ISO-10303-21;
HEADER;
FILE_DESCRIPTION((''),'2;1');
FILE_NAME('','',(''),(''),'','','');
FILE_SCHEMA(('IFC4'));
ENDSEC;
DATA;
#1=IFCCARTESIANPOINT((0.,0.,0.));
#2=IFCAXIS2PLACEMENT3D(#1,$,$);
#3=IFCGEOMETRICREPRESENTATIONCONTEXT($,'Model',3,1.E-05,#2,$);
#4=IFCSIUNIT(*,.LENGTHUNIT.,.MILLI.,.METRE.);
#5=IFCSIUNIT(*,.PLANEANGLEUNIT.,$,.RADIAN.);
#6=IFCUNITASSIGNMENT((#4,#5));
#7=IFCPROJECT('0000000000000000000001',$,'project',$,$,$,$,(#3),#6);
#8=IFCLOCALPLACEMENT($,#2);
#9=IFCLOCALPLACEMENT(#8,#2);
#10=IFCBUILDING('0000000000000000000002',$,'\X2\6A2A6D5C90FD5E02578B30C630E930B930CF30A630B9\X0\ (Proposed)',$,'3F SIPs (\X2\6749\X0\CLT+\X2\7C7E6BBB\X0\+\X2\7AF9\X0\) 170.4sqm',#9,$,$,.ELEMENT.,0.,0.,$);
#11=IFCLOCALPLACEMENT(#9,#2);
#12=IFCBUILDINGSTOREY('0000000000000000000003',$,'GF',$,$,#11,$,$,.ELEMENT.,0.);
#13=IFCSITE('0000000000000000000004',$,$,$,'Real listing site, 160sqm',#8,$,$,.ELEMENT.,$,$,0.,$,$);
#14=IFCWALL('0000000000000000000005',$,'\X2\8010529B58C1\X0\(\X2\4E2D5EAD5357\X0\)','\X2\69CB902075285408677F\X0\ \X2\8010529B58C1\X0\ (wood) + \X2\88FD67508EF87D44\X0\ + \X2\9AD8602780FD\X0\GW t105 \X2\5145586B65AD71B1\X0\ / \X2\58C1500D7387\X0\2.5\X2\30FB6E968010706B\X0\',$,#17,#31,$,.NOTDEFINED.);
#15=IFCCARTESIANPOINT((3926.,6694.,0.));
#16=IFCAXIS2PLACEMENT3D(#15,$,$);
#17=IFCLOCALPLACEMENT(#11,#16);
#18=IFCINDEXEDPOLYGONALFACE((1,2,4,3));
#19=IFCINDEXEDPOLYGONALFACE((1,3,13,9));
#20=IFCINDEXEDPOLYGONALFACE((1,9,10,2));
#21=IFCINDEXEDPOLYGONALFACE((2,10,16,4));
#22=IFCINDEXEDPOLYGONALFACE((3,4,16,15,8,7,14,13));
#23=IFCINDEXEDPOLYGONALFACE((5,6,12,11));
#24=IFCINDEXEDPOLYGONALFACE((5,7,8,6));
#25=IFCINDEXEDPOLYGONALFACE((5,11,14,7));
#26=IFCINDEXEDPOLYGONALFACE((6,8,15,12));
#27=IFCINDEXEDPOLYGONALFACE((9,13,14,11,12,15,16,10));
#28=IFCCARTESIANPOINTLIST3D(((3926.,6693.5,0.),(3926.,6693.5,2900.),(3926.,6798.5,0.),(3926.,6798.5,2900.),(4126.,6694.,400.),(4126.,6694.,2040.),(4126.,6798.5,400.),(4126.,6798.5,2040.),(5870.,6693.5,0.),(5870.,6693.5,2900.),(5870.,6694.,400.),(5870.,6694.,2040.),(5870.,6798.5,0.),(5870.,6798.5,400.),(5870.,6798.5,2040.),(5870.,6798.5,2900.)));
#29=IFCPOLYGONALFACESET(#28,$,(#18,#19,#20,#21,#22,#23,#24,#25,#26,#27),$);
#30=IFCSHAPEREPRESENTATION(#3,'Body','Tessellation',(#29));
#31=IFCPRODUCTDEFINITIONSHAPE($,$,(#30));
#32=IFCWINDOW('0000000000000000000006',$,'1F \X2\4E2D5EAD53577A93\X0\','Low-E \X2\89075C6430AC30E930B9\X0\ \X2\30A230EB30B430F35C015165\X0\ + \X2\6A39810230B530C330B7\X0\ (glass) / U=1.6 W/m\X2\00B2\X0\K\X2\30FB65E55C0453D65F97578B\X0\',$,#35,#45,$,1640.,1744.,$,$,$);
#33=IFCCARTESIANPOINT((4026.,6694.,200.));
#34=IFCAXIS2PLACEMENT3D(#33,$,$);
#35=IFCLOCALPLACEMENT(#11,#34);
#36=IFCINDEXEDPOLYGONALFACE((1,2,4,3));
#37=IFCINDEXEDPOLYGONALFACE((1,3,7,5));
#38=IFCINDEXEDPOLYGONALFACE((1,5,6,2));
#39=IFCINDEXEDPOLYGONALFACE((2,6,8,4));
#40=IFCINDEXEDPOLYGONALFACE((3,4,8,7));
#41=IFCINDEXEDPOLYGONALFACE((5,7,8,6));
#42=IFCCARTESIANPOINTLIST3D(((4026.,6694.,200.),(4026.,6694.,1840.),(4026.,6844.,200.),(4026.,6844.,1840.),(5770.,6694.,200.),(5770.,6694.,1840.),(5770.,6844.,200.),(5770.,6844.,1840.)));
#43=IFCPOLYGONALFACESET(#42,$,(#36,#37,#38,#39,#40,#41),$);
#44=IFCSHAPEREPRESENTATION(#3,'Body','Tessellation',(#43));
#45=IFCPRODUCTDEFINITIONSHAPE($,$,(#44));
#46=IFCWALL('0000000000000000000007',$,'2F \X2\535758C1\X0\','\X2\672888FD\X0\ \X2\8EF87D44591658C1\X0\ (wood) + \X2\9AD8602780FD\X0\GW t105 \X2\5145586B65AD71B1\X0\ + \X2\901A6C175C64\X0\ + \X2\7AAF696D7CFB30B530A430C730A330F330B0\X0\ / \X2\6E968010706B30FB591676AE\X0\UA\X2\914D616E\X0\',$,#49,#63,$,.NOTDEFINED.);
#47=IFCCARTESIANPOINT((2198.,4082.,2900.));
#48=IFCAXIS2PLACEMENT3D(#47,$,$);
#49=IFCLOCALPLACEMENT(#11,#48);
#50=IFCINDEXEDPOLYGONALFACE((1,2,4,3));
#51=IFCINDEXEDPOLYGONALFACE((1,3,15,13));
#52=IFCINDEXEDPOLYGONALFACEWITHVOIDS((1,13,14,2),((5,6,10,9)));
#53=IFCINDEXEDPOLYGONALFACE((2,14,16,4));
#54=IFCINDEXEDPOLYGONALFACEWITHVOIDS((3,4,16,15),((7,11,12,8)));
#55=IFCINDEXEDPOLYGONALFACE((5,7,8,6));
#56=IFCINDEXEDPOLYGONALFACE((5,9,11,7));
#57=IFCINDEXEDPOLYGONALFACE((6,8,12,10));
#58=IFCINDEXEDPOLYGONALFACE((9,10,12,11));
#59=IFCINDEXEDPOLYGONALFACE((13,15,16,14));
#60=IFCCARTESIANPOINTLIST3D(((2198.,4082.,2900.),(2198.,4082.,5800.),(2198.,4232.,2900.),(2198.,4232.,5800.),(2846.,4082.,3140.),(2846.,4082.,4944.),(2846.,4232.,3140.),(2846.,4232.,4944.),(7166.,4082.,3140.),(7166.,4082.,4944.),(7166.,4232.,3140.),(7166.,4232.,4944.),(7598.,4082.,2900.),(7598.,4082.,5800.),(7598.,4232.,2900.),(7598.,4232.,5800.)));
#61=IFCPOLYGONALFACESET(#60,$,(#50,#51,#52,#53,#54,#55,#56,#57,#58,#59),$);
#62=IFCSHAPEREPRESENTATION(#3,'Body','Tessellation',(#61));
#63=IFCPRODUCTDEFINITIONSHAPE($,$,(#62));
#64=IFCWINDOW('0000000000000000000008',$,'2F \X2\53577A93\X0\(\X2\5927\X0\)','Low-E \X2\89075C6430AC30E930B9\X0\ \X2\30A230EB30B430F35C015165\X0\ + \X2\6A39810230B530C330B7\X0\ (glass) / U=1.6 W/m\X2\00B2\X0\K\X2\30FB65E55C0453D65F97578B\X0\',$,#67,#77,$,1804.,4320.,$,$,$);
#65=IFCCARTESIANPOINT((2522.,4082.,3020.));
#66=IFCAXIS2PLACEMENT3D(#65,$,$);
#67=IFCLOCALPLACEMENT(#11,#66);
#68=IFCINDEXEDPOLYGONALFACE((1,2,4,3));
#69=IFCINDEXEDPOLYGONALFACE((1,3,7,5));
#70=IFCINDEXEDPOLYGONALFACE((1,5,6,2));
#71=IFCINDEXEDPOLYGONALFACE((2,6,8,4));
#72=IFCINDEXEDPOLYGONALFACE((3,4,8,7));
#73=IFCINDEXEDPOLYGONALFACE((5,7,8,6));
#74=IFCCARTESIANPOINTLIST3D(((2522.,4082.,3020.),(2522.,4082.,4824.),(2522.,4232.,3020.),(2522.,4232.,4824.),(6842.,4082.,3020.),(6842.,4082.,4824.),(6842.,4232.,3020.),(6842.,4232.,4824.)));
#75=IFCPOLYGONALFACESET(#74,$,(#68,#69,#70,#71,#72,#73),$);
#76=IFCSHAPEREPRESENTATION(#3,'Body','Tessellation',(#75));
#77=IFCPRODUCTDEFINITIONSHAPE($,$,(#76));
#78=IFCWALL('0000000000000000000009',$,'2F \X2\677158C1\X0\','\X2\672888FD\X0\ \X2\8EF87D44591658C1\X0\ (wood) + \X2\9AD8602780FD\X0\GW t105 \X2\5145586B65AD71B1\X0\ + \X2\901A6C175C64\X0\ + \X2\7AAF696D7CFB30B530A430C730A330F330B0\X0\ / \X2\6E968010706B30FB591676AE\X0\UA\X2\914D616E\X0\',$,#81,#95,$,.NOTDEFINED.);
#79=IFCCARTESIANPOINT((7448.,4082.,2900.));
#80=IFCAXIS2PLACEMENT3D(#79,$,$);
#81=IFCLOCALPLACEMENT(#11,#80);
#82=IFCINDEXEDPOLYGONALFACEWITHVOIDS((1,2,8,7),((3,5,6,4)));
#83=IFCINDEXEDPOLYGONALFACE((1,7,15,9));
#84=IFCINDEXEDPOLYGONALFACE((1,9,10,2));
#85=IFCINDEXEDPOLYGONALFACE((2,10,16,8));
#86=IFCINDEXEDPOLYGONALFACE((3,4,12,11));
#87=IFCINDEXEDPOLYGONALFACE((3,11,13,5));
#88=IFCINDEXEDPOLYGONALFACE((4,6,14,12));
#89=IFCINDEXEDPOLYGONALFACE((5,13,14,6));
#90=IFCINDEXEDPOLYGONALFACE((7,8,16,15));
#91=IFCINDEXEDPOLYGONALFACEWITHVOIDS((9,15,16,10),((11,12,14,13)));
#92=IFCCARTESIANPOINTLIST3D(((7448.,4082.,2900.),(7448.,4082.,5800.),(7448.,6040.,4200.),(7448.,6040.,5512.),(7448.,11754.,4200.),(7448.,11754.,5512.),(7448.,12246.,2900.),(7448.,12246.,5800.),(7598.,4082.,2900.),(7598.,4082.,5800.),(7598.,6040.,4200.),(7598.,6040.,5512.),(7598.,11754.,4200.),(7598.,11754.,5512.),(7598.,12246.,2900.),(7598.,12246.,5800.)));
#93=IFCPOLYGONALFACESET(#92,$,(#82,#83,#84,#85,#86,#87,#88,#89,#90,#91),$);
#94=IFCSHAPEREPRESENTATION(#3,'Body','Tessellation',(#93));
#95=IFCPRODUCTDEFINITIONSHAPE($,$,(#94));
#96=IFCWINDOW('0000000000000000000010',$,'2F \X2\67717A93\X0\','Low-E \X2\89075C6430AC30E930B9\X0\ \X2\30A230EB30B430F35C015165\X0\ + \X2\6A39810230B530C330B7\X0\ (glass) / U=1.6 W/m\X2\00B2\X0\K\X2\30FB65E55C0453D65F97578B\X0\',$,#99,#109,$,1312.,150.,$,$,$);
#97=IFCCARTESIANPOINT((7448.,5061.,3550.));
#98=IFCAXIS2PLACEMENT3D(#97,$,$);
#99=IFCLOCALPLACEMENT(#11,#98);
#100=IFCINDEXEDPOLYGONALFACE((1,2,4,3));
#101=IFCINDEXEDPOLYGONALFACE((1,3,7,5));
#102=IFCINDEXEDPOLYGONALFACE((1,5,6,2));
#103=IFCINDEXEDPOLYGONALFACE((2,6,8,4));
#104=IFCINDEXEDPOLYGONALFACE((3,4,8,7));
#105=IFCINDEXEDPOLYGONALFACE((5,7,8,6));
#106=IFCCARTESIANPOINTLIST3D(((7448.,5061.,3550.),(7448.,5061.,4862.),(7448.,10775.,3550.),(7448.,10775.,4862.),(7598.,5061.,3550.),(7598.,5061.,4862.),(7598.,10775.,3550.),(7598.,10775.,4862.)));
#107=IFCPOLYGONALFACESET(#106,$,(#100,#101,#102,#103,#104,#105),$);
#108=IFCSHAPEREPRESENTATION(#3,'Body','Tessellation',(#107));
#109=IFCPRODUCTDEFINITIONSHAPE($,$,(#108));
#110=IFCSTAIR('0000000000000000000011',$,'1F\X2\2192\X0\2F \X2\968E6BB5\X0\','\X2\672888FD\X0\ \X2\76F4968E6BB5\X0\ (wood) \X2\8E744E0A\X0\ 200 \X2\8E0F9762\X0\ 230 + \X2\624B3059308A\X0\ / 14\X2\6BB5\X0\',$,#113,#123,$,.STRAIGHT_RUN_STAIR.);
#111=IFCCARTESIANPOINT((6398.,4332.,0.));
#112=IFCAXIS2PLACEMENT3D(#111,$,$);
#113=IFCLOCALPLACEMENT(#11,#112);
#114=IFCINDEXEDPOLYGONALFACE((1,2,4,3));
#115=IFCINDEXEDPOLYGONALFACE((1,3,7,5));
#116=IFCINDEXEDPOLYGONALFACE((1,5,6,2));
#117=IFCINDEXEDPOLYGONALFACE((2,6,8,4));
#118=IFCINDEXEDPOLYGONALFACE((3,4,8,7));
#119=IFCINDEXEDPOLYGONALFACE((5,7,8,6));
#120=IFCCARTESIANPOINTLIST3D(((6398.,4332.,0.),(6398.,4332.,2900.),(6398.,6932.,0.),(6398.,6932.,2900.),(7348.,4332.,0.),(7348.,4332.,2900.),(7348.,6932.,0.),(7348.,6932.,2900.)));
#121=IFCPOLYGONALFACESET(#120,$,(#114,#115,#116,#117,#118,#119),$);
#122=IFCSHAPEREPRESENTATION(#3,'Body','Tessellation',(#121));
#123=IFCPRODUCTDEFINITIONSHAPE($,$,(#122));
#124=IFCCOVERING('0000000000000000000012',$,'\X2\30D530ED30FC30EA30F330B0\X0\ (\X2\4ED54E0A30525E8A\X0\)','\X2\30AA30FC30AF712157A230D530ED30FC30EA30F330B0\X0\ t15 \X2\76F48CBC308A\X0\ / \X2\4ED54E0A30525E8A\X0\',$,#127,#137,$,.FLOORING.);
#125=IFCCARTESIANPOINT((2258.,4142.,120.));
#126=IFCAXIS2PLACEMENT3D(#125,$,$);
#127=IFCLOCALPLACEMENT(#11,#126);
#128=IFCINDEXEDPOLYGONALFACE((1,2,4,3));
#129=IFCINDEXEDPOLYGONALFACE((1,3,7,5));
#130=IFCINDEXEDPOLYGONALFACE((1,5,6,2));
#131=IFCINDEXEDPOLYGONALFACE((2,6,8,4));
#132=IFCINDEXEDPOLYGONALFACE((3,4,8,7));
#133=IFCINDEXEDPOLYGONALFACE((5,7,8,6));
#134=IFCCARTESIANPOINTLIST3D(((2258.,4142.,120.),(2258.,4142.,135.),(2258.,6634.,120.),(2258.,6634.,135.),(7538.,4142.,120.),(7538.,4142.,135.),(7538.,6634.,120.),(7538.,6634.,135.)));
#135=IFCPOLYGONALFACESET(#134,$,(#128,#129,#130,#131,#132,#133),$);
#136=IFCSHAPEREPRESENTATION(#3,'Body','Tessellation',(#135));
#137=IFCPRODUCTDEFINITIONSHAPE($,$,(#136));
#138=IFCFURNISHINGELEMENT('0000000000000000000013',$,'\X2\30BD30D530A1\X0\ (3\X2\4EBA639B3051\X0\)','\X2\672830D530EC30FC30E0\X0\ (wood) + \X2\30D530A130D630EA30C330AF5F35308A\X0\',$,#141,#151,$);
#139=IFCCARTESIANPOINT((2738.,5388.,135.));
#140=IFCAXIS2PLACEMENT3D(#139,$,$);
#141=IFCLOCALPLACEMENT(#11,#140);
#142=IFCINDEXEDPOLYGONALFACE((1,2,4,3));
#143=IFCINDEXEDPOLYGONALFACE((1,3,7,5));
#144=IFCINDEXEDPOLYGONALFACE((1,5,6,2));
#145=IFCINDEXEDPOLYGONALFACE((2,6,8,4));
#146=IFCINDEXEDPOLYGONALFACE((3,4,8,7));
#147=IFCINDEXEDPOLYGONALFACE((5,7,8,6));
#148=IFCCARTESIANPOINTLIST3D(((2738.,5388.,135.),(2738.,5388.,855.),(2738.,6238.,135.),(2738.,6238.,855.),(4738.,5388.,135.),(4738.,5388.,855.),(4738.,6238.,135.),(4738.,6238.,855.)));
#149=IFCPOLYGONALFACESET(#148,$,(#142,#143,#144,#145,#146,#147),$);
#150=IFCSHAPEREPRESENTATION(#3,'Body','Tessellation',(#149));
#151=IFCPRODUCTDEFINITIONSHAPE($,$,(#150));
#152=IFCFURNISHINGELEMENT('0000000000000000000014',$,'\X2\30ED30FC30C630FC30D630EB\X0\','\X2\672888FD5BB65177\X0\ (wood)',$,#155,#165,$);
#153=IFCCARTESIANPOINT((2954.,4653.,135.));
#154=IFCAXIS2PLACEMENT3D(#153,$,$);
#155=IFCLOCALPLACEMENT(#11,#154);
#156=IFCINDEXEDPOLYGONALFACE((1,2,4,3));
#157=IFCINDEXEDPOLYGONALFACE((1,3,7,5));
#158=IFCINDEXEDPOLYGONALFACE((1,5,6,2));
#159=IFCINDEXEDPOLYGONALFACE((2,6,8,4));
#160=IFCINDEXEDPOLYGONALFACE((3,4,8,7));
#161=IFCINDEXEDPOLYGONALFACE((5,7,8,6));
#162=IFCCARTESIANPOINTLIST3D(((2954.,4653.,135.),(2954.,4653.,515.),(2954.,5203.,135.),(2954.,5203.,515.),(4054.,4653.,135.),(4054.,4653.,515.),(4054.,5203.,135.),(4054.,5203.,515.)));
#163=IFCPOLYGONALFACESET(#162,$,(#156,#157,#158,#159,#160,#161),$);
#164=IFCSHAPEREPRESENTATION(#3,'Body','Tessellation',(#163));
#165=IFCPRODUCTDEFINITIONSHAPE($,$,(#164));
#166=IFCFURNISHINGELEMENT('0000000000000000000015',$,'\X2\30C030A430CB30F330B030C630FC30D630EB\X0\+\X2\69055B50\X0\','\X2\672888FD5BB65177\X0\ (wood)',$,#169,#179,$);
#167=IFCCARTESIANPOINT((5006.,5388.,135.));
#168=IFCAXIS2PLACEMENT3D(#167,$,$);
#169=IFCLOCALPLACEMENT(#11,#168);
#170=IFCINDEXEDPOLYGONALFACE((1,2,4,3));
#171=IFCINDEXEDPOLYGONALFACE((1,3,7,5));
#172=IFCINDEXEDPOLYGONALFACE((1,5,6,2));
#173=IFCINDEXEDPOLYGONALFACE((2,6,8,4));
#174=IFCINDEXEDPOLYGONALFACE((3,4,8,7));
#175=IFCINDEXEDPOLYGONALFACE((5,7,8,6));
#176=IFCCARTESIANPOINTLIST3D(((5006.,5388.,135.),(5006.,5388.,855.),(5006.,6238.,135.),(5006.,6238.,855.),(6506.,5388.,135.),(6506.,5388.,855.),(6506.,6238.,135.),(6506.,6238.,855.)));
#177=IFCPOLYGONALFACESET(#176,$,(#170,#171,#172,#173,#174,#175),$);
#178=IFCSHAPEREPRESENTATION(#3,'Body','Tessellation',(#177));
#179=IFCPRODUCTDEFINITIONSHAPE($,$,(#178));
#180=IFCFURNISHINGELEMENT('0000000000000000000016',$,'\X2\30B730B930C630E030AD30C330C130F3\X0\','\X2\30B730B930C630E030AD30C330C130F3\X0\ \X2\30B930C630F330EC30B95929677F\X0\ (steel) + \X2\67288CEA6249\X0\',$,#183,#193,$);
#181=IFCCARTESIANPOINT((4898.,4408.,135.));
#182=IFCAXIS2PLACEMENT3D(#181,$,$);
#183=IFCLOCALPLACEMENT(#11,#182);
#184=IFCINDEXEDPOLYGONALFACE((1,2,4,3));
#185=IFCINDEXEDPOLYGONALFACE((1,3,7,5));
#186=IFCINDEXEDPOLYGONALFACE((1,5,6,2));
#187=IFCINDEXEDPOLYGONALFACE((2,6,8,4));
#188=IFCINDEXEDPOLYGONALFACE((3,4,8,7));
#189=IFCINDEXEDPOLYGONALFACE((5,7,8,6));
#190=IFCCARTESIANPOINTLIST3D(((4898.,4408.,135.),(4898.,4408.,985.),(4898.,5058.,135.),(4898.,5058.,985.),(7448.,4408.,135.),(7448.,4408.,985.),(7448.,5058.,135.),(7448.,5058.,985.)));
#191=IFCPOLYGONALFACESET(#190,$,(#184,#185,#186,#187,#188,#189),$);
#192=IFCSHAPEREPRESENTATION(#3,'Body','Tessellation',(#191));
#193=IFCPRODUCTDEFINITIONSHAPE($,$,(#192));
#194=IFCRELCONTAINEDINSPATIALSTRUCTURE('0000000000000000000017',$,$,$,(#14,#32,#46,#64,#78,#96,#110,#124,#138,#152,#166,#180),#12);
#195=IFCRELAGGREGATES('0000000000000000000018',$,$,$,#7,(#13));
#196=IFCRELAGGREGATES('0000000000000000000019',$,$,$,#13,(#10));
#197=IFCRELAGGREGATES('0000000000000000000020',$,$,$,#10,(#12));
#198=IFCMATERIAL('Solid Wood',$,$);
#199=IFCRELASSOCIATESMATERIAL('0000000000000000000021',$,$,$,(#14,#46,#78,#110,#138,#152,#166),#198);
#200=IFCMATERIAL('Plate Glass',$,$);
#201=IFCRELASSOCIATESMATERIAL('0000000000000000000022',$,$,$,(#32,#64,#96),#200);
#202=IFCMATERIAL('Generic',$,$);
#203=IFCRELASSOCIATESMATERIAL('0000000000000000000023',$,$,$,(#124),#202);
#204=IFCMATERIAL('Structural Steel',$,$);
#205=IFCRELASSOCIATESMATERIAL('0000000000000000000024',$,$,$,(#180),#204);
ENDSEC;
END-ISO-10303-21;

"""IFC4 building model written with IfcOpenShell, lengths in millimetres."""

from ifc_helpers import new_model, si_unit, frame, frame_2d, origin, place, context, project, spatial, rectangle, extrude, material, element, fill, save


model = new_model("IFC4")

# Units and contexts
model_context = context("Model", 3, precision=1e-05, world=origin())
ifc_project = project(units=[si_unit("LENGTHUNIT", "METRE", prefix="MILLI"), si_unit("PLANEANGLEUNIT", "RADIAN")], contexts=[model_context])

# Site, building, storey
site_placement = place(None, origin())
site = spatial("IfcSite", under=ifc_project, at=site_placement, ObjectType="Real listing site, 160sqm", CompositionType="ELEMENT", RefElevation=0.0)
building_placement = place(site_placement, origin())
building = spatial("IfcBuilding", under=site, at=building_placement, Name="横浜都市型テラスハウス (Proposed)", ObjectType="3F SIPs (杉CLT+籾殻+竹) 170.4sqm", CompositionType="ELEMENT", ElevationOfRefHeight=0.0, ElevationOfTerrain=0.0)
storey_placement = place(building_placement, origin())
storey = spatial("IfcBuildingStorey", under=building, at=storey_placement, Name="GF", CompositionType="ELEMENT", Elevation=0.0)

# Shared definitions
ifc_material_1 = material(Name="Solid Wood")
ifc_material_2 = material(Name="Generic")

# Shared definitions
ifc_material_3 = material(Name="Plate Glass")

# Wall, opening, window
wall_1_placement = place(storey_placement, frame((3926.0, 6694.0, 0.0)))
wall_1 = element("IfcWall", 1, at=wall_1_placement, inside=storey, material=ifc_material_1, Name="耐力壁(中庭南)", Description="構造用合板 耐力壁 (wood) + 製材軸組 + 高性能GW t105 充填断熱 / 壁倍率2.5・準耐火", PredefinedType="NOTDEFINED", context=model_context, shape_type="SweptSolid", body=[
    extrude(rectangle(XDim=1944.0, YDim=105.0, at=frame_2d((972.0, 52.0))), frame((3926.0, 6694.0, 0.0)), (0.0, 0.0, 1.0), 2900.0),
])
opening_1_placement = place(storey_placement, frame((4026.0, 6694.0, 200.0)))
opening_1 = element("IfcOpeningElement", 2, at=opening_1_placement, cuts=wall_1, PredefinedType="NOTDEFINED", context=model_context, shape_type="SweptSolid", body=[
    extrude(rectangle(XDim=1744.0, YDim=150.0, at=frame_2d((872.0, 75.0))), frame((4026.0, 6694.0, 200.0)), (0.0, 0.0, 1.0), 1640.0),
])
window_1_placement = place(storey_placement, frame((4026.0, 6694.0, 200.0)))
window_1 = element("IfcWindow", 3, at=window_1_placement, inside=storey, material=ifc_material_3, Name="1F 中庭南窓", Description="Low-E 複層ガラス アルゴン封入 + 樹脂サッシ (glass) / U=1.6 W/m²K・日射取得型", OverallHeight=1640.0, OverallWidth=1744.0, context=model_context, shape_type="SweptSolid", body=[
    extrude(rectangle(XDim=1744.0, YDim=150.0, at=frame_2d((872.0, 75.0))), frame((4026.0, 6694.0, 200.0)), (0.0, 0.0, 1.0), 1640.0),
])
fill(opening_1, window_1)

# Walls, openings, windows
wall_2_placement = place(storey_placement, frame((2198.0, 4082.0, 2900.0)))
wall_2 = element("IfcWall", 4, at=wall_2_placement, inside=storey, material=ifc_material_1, Name="2F 南壁", Description="木製 軸組外壁 (wood) + 高性能GW t105 充填断熱 + 通気層 + 窯業系サイディング / 準耐火・外皮UA配慮", PredefinedType="NOTDEFINED", context=model_context, shape_type="SweptSolid", body=[
    extrude(rectangle(XDim=5400.0, YDim=150.0, at=frame_2d((2700.0, 75.0))), frame((2198.0, 4082.0, 2900.0)), (0.0, 0.0, 1.0), 2900.0),
])
opening_2_placement = place(storey_placement, frame((2522.0, 4082.0, 3020.0)))
opening_2 = element("IfcOpeningElement", 5, at=opening_2_placement, cuts=wall_2, PredefinedType="NOTDEFINED", context=model_context, shape_type="SweptSolid", body=[
    extrude(rectangle(XDim=4320.0, YDim=150.0, at=frame_2d((2160.0, 75.0))), frame((2522.0, 4082.0, 3020.0)), (0.0, 0.0, 1.0), 1804.0),
])
window_2_placement = place(storey_placement, frame((2522.0, 4082.0, 3020.0)))
window_2 = element("IfcWindow", 6, at=window_2_placement, inside=storey, material=ifc_material_3, Name="2F 南窓(大)", Description="Low-E 複層ガラス アルゴン封入 + 樹脂サッシ (glass) / U=1.6 W/m²K・日射取得型", OverallHeight=1804.0, OverallWidth=4320.0, context=model_context, shape_type="SweptSolid", body=[
    extrude(rectangle(XDim=4320.0, YDim=150.0, at=frame_2d((2160.0, 75.0))), frame((2522.0, 4082.0, 3020.0)), (0.0, 0.0, 1.0), 1804.0),
])
fill(opening_2, window_2)
wall_3_placement = place(storey_placement, frame((7448.0, 4082.0, 2900.0)))
wall_3 = element("IfcWall", 7, at=wall_3_placement, inside=storey, material=ifc_material_1, Name="2F 東壁", Description="木製 軸組外壁 (wood) + 高性能GW t105 充填断熱 + 通気層 + 窯業系サイディング / 準耐火・外皮UA配慮", PredefinedType="NOTDEFINED", context=model_context, shape_type="SweptSolid", body=[
    extrude(rectangle(XDim=150.0, YDim=8164.0, at=frame_2d((75.0, 4082.0))), frame((7448.0, 4082.0, 2900.0)), (0.0, 0.0, 1.0), 2900.0),
])
opening_3_placement = place(storey_placement, frame((7448.0, 5061.0, 3550.0)))
opening_3 = element("IfcOpeningElement", 8, at=opening_3_placement, cuts=wall_3, PredefinedType="NOTDEFINED", context=model_context, shape_type="SweptSolid", body=[
    extrude(rectangle(XDim=150.0, YDim=5714.0, at=frame_2d((75.0, 2857.0))), frame((7448.0, 5061.0, 3550.0)), (0.0, 0.0, 1.0), 1312.0),
])
window_3_placement = place(storey_placement, frame((7448.0, 5061.0, 3550.0)))
window_3 = element("IfcWindow", 9, at=window_3_placement, inside=storey, material=ifc_material_3, Name="2F 東窓", Description="Low-E 複層ガラス アルゴン封入 + 樹脂サッシ (glass) / U=1.6 W/m²K・日射取得型", OverallHeight=1312.0, OverallWidth=150.0, context=model_context, shape_type="SweptSolid", body=[
    extrude(rectangle(XDim=150.0, YDim=5714.0, at=frame_2d((75.0, 2857.0))), frame((7448.0, 5061.0, 3550.0)), (0.0, 0.0, 1.0), 1312.0),
])
fill(opening_3, window_3)

# Stair
stair_placement = place(storey_placement, frame((6398.0, 4332.0, 0.0)))
element("IfcStair", 10, at=stair_placement, inside=storey, material=ifc_material_1, Name="1F→2F 階段", Description="木製 直階段 (wood) 蹴上 200 踏面 230 + 手すり / 14段", PredefinedType="STRAIGHT_RUN_STAIR", context=model_context, shape_type="SweptSolid", body=[
    extrude(rectangle(XDim=950.0, YDim=2600.0, at=frame_2d((475.0, 1300.0))), frame((6398.0, 4332.0, 0.0)), (0.0, 0.0, 1.0), 2900.0),
])

# Covering
covering_placement = place(storey_placement, frame((2258.0, 4142.0, 120.0)))
element("IfcCovering", 11, at=covering_placement, inside=storey, material=ifc_material_2, Name="フローリング (仕上げ床)", Description="オーク無垢フローリング t15 直貼り / 仕上げ床", PredefinedType="FLOORING", context=model_context, shape_type="SweptSolid", body=[
    extrude(rectangle(XDim=5280.0, YDim=2492.0, at=frame_2d((2640.0, 1246.0))), frame((2258.0, 4142.0, 120.0)), (0.0, 0.0, 1.0), 15.0),
])

# Furnishing elements
furnishing_1_placement = place(storey_placement, frame((2738.0, 5388.0, 135.0)))
element("IfcFurnishingElement", 12, at=furnishing_1_placement, inside=storey, material=ifc_material_1, Name="ソファ (3人掛け)", Description="木フレーム (wood) + ファブリック張り", context=model_context, shape_type="SweptSolid", body=[
    extrude(rectangle(XDim=2000.0, YDim=850.0, at=frame_2d((1000.0, 425.0))), frame((2738.0, 5388.0, 135.0)), (0.0, 0.0, 1.0), 720.0),
])
furnishing_2_placement = place(storey_placement, frame((2954.0, 4653.0, 135.0)))
element("IfcFurnishingElement", 13, at=furnishing_2_placement, inside=storey, material=ifc_material_1, Name="ローテーブル", Description="木製家具 (wood)", context=model_context, shape_type="SweptSolid", body=[
    extrude(rectangle(XDim=1100.0, YDim=550.0, at=frame_2d((550.0, 275.0))), frame((2954.0, 4653.0, 135.0)), (0.0, 0.0, 1.0), 380.0),
])
furnishing_3_placement = place(storey_placement, frame((5006.0, 5388.0, 135.0)))
element("IfcFurnishingElement", 14, at=furnishing_3_placement, inside=storey, material=ifc_material_1, Name="ダイニングテーブル+椅子", Description="木製家具 (wood)", context=model_context, shape_type="SweptSolid", body=[
    extrude(rectangle(XDim=1500.0, YDim=850.0, at=frame_2d((750.0, 425.0))), frame((5006.0, 5388.0, 135.0)), (0.0, 0.0, 1.0), 720.0),
])
ifc_material_4 = material(Name="Structural Steel")
furnishing_4_placement = place(storey_placement, frame((4898.0, 4408.0, 135.0)))
element("IfcFurnishingElement", 15, at=furnishing_4_placement, inside=storey, material=ifc_material_4, Name="システムキッチン", Description="システムキッチン ステンレス天板 (steel) + 木質扉", context=model_context, shape_type="SweptSolid", body=[
    extrude(rectangle(XDim=2550.0, YDim=650.0, at=frame_2d((1275.0, 325.0))), frame((4898.0, 4408.0, 135.0)), (0.0, 0.0, 1.0), 850.0),
])

save(model, "model.ifc")
